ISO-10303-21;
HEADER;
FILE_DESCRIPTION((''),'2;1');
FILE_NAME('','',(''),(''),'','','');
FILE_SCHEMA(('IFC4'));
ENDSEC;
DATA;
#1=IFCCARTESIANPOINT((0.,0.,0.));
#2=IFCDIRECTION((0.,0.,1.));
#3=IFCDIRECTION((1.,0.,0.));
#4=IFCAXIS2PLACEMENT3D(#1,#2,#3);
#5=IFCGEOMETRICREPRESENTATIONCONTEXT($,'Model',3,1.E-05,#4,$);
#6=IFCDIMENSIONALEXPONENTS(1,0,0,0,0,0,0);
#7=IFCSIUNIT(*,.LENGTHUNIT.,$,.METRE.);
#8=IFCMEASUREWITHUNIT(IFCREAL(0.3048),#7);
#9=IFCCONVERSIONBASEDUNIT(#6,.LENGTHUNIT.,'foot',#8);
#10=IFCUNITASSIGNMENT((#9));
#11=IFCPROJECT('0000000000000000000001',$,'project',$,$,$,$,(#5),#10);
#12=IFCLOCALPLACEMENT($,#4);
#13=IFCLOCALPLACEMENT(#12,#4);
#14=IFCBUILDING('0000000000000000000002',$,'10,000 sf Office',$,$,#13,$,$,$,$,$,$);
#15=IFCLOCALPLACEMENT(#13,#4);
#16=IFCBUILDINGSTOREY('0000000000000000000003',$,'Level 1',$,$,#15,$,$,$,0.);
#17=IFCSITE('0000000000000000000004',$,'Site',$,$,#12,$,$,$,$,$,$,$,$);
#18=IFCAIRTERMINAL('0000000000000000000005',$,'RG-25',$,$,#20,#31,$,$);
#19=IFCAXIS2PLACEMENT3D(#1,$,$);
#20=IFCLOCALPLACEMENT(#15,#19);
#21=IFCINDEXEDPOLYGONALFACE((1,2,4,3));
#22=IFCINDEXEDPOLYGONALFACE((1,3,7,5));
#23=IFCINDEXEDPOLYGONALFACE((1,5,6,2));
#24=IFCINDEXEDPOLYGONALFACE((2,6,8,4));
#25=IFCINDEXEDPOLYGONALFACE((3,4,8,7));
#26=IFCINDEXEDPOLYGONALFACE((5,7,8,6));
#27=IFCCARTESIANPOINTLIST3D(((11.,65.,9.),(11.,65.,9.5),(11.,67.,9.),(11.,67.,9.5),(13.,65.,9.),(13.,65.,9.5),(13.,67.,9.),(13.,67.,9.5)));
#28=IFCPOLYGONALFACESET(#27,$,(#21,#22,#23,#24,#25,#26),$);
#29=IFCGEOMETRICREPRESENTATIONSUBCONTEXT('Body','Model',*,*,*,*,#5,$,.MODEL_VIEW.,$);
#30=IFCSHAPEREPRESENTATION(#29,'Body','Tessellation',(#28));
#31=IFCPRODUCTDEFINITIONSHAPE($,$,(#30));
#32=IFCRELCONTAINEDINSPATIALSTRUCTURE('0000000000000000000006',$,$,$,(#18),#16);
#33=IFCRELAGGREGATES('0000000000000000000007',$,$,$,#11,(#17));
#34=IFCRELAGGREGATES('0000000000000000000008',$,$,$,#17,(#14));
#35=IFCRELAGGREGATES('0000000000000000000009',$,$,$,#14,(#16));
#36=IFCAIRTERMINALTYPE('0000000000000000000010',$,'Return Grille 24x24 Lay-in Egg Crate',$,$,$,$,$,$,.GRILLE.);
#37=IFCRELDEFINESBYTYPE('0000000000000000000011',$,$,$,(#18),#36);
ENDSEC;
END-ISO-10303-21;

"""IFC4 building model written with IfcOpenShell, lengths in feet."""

from ifc_helpers import new_model, entity, si_unit, converted_unit, frame, origin_with_axes, place, context, subcontext, project, spatial, rectangle, extrude, type_object, element, save


model = new_model("IFC4")

# Units and contexts
model_context = context("Model", 3, precision=1e-05, world=origin_with_axes())
body_context = subcontext(model_context, "Body", "Model", "MODEL_VIEW")
ifc_project = project(units=[converted_unit("LENGTHUNIT", "foot", entity("IfcReal", 0.3048), si_unit("LENGTHUNIT", "METRE"), dimensions=[1, 0, 0, 0, 0, 0, 0])], contexts=[model_context])

# Site, building, storey
site_placement = place(None, origin_with_axes())
site = spatial("IfcSite", under=ifc_project, at=site_placement, Name="Site")
building_placement = place(site_placement, origin_with_axes())
building = spatial("IfcBuilding", under=site, at=building_placement, Name="10,000 sf Office")
storey_placement = place(building_placement, origin_with_axes())
storey = spatial("IfcBuildingStorey", under=building, at=storey_placement, Name="Level 1", Elevation=0.0)

# Air terminal
air_terminal_type_1 = type_object("IfcAirTerminalType", Name="Return Grille 24x24 Lay-in Egg Crate", PredefinedType="GRILLE")
for number, where, z_axis, x_axis, name in (
    (1, (12.0, 66.0, 9.0), (0.0, 0.0, 1.0), (1.0, 0.0, 0.0), "RG-25"),
):
    element("IfcAirTerminal", number, at=place(storey_placement, frame(where, z_axis=z_axis, x_axis=x_axis)), inside=storey, type_object=air_terminal_type_1, Name=name, context=body_context, shape_type="SweptSolid", body=[
        extrude(rectangle(XDim=2.0, YDim=2.0), None, (0.0, 0.0, 1.0), 0.5),
    ])

save(model, "model.ifc")
